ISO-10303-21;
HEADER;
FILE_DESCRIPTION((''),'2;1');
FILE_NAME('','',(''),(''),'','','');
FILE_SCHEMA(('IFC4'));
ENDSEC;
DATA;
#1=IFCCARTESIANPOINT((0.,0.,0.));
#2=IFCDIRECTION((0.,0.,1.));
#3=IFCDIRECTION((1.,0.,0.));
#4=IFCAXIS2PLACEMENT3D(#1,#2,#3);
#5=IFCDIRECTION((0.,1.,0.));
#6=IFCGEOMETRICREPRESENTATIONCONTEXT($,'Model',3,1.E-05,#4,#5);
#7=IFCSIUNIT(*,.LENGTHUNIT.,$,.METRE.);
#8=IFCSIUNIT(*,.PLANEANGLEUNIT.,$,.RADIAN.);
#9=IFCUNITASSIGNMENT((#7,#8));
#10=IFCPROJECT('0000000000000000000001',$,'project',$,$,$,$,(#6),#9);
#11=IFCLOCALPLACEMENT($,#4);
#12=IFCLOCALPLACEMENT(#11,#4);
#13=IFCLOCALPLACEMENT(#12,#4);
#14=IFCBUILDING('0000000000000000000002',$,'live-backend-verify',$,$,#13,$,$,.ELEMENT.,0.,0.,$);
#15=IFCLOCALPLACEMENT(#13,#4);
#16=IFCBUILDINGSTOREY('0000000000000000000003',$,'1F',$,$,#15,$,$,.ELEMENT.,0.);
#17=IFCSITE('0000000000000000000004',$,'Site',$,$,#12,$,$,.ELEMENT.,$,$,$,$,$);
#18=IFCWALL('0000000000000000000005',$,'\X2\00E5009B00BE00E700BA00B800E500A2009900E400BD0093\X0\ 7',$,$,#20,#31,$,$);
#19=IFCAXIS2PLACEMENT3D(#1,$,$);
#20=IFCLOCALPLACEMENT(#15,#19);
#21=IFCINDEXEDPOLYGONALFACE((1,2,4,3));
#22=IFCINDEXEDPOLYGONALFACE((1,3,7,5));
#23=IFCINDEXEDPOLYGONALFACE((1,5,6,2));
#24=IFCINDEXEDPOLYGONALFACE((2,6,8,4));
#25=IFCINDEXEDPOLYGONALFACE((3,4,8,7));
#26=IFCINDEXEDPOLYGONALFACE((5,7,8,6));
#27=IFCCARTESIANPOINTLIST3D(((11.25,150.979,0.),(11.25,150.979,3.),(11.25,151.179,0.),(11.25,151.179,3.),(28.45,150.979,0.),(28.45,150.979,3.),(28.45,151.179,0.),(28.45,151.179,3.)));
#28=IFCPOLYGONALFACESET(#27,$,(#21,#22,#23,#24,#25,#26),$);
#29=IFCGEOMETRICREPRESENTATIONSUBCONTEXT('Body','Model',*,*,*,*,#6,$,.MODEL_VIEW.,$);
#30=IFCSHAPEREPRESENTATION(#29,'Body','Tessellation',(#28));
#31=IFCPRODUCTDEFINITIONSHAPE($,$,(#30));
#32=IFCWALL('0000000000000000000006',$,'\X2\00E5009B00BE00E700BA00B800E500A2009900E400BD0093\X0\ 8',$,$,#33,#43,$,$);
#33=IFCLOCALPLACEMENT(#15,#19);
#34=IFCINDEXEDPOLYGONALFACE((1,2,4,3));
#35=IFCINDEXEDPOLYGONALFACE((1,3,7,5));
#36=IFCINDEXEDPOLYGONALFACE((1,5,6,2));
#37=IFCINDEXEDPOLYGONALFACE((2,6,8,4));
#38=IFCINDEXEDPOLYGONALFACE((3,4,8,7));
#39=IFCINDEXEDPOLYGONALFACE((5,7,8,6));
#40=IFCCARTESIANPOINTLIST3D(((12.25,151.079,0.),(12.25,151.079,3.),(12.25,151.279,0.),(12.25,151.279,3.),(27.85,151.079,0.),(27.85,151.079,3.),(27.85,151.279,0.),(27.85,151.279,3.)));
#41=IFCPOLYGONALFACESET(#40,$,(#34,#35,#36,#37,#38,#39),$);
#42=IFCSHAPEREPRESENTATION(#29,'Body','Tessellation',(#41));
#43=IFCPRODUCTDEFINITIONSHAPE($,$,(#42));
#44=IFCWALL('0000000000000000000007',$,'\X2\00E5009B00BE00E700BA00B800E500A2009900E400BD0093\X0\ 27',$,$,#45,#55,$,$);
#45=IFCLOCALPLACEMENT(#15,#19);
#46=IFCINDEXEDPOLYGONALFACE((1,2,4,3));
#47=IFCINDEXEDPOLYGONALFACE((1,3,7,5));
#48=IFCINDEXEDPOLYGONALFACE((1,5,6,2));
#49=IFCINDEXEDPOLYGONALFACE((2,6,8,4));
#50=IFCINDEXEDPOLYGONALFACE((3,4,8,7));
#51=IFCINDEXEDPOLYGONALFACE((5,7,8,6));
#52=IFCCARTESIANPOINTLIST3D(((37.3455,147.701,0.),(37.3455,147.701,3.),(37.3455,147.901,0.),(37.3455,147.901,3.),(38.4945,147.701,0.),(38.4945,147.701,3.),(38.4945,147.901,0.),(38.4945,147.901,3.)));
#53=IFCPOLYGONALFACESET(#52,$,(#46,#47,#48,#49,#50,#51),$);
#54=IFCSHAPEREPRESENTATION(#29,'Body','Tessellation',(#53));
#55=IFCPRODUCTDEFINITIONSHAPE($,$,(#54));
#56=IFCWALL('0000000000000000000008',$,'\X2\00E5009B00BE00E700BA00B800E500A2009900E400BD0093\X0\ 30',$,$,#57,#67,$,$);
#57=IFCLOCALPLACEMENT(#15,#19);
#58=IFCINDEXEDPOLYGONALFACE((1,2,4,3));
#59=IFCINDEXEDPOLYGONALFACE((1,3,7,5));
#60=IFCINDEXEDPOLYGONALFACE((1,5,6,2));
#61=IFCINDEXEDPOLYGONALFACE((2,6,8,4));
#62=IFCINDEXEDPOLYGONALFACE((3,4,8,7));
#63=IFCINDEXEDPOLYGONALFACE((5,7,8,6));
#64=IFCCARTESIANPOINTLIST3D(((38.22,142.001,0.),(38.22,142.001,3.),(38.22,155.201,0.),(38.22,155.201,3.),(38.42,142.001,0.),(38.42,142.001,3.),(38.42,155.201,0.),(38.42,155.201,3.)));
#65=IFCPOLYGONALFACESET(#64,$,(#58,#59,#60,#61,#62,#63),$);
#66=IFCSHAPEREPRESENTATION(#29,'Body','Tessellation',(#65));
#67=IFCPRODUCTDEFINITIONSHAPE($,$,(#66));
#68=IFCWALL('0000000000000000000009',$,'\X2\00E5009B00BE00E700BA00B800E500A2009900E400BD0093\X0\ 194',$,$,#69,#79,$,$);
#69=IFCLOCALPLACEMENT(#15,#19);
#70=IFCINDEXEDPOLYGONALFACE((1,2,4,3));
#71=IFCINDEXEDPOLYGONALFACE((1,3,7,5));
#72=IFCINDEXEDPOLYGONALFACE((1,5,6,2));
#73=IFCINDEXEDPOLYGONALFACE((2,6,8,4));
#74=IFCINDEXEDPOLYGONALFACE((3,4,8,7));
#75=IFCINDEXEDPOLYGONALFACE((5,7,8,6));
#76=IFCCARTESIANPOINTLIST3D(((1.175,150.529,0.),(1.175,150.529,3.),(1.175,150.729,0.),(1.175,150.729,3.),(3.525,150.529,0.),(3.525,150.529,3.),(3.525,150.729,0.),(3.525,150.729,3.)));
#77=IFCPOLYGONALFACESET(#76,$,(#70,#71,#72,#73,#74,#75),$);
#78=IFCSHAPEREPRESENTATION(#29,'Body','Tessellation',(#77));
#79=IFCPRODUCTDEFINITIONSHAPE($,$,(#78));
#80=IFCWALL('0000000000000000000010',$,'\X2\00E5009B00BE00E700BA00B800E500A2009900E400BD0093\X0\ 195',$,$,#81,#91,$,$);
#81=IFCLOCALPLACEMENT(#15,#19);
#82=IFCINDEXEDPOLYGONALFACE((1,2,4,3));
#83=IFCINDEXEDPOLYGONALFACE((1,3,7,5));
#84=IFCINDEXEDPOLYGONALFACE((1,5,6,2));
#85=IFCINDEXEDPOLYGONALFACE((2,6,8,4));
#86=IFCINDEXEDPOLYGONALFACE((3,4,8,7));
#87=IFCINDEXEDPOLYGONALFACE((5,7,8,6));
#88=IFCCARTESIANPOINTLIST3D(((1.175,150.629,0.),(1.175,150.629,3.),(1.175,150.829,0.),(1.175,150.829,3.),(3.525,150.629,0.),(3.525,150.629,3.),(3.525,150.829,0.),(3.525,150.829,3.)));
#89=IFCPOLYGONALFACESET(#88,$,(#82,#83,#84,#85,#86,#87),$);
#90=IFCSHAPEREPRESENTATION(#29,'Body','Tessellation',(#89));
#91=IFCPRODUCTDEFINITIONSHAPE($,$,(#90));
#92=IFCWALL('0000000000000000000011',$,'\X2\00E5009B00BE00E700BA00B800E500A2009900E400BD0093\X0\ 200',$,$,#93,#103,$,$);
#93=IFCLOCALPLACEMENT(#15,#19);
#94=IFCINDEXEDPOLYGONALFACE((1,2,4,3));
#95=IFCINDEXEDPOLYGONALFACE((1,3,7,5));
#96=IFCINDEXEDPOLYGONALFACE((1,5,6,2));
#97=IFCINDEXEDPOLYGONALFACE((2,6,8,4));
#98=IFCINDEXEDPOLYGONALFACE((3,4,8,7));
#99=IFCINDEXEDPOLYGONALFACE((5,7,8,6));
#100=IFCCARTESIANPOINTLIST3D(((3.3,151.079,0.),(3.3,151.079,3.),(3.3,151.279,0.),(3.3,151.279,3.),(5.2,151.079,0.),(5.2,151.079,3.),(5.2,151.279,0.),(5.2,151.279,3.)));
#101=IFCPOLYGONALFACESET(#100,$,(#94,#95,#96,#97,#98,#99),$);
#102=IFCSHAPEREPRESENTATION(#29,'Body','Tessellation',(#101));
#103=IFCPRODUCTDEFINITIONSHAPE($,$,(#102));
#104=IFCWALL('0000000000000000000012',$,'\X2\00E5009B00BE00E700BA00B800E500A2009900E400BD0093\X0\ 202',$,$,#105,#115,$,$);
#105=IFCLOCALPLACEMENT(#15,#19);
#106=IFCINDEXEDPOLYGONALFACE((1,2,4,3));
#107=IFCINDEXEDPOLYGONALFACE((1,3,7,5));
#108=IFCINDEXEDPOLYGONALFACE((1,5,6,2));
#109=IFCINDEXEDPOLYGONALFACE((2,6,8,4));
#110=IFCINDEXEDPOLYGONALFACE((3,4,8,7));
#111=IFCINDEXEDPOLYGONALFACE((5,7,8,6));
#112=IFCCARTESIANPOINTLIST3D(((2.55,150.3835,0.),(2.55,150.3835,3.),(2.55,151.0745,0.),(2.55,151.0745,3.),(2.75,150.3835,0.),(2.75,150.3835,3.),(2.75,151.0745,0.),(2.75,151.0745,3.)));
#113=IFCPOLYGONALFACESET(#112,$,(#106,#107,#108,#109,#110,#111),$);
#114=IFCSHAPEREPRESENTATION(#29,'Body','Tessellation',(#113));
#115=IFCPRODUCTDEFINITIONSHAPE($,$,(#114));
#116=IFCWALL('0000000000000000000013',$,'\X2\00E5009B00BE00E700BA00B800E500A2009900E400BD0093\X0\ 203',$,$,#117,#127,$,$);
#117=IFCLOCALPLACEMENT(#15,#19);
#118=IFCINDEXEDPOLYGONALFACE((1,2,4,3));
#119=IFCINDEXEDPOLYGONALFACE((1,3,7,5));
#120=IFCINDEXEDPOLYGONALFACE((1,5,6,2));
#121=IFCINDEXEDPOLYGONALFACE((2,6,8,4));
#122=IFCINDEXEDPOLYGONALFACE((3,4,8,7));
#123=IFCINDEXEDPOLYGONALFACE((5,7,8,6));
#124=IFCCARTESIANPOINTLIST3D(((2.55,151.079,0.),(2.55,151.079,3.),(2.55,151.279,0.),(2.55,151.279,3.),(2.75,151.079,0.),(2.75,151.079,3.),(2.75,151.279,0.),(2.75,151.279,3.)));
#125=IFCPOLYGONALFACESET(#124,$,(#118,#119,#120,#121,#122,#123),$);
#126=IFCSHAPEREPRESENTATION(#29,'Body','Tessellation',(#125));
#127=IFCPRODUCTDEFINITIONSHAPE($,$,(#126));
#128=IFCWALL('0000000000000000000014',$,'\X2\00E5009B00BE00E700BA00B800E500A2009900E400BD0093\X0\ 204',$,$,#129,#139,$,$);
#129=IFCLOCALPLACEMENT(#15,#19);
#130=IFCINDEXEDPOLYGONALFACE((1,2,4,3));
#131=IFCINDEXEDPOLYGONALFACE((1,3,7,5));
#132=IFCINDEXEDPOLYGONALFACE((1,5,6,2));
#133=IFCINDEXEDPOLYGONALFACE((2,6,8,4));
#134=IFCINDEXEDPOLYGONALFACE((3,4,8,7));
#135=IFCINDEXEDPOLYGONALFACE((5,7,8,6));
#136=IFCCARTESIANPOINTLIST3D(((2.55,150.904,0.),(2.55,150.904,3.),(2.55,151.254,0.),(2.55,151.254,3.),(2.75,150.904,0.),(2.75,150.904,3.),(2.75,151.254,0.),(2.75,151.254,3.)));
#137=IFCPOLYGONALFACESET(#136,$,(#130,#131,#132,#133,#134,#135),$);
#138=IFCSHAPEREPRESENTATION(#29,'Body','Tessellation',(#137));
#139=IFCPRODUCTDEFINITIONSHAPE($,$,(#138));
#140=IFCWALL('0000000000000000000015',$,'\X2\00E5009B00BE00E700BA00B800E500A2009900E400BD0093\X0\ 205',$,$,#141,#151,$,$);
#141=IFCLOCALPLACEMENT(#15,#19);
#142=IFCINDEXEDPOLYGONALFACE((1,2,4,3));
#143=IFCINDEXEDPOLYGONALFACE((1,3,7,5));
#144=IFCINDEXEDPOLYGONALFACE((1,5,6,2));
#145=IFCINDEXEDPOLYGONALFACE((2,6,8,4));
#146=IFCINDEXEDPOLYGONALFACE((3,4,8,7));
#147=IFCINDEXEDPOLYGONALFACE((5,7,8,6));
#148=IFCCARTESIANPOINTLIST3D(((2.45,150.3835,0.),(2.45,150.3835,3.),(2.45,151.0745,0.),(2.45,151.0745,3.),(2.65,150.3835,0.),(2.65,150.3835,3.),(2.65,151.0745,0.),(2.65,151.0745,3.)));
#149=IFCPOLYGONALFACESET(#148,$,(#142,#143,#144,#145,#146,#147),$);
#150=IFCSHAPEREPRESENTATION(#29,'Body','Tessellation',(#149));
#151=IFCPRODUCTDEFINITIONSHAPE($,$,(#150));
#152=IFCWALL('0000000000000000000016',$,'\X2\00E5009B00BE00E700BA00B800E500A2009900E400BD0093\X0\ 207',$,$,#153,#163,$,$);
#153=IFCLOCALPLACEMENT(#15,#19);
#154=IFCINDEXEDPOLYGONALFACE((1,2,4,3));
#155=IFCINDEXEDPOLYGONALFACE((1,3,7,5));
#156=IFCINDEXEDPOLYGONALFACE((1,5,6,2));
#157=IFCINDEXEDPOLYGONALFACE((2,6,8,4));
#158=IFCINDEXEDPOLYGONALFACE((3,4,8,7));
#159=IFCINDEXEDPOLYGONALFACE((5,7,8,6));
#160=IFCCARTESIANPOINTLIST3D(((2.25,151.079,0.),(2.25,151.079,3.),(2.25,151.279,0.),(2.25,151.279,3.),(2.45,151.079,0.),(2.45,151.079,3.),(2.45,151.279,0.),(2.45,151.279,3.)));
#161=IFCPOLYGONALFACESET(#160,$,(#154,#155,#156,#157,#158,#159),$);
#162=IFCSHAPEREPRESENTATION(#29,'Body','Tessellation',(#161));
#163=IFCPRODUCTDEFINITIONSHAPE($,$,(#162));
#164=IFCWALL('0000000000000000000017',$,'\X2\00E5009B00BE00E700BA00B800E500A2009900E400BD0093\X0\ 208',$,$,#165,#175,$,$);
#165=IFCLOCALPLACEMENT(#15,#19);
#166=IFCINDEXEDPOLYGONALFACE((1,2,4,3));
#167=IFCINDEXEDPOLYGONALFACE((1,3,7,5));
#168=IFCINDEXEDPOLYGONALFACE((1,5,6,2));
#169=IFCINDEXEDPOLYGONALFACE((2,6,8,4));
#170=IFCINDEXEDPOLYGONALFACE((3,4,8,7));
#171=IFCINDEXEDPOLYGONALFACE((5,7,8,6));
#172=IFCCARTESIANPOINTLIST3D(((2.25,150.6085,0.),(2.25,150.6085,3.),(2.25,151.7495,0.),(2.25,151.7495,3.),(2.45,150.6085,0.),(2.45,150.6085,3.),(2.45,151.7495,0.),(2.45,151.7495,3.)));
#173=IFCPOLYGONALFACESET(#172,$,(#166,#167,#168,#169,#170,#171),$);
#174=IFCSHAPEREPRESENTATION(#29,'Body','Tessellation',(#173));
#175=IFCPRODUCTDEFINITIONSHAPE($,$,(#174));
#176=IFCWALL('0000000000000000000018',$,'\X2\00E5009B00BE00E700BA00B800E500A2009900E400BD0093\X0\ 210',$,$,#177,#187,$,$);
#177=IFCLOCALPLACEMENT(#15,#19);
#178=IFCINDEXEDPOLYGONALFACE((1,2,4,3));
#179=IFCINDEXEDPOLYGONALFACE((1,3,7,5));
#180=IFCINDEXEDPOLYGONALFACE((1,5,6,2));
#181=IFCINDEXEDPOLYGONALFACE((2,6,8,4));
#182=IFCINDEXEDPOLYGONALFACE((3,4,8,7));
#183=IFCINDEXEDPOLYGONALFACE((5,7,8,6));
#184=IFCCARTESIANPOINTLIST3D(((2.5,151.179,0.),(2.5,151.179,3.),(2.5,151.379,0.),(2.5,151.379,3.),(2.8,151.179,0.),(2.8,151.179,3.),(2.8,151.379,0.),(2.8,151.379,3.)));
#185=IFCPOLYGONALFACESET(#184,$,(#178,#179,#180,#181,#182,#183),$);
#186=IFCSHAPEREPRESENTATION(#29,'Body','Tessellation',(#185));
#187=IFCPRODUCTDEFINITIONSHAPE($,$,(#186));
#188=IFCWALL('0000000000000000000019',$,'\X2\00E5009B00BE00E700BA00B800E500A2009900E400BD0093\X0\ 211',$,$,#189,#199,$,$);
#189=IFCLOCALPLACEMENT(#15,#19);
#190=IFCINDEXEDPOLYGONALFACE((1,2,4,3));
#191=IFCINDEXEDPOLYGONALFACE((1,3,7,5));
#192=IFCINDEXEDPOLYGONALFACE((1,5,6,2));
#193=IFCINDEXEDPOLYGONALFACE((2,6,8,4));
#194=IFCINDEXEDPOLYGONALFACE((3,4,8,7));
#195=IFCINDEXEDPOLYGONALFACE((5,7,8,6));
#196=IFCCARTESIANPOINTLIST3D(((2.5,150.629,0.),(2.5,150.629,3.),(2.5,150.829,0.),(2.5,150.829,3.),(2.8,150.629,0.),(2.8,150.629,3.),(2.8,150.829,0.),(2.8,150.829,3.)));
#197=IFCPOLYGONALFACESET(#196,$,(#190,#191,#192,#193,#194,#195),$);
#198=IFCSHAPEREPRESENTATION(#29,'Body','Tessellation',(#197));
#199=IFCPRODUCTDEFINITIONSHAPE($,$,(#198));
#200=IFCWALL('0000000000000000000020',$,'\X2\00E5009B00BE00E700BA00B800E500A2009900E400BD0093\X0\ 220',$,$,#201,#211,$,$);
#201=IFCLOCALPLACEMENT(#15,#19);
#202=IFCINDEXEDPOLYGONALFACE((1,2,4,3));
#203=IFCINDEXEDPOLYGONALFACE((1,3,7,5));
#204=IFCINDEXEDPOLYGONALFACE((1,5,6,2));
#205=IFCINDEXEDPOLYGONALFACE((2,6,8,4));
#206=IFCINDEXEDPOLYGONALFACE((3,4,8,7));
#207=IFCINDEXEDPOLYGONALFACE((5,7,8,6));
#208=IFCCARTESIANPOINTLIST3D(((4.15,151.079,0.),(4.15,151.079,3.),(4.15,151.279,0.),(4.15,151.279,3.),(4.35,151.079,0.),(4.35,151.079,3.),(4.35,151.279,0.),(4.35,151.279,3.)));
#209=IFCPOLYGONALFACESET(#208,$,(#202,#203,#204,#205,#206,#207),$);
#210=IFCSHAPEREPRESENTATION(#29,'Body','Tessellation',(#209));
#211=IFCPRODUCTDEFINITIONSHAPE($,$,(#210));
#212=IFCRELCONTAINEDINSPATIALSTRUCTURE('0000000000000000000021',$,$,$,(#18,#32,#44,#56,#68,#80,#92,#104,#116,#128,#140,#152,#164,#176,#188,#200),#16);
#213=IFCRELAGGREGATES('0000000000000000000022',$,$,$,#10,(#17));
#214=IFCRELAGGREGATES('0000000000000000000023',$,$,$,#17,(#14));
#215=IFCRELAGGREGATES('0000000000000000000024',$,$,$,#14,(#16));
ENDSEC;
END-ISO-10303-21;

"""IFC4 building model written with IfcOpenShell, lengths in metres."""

from ifc_helpers import new_model, si_unit, direction, frame, frame_2d, origin_with_axes, place, context, subcontext, project, spatial, rectangle, extrude, element, save


model = new_model("IFC4")

# Units and contexts
model_context = context("Model", 3, precision=1e-05, world=origin_with_axes(), true_north=direction((0.0, 1.0, 0.0)))
body_context = subcontext(model_context, "Body", "Model", "MODEL_VIEW")
ifc_project = project(units=[si_unit("LENGTHUNIT", "METRE"), si_unit("PLANEANGLEUNIT", "RADIAN")], contexts=[model_context])

# Site, building, storey
placement = place(None, origin_with_axes())
site_placement = place(placement, origin_with_axes())
site = spatial("IfcSite", under=ifc_project, at=site_placement, Name="Site", CompositionType="ELEMENT")
building_placement = place(site_placement, origin_with_axes())
building = spatial("IfcBuilding", under=site, at=building_placement, Name="live-backend-verify", CompositionType="ELEMENT", ElevationOfRefHeight=0.0, ElevationOfTerrain=0.0)
storey_placement = place(building_placement, origin_with_axes())
storey = spatial("IfcBuildingStorey", under=building, at=storey_placement, Name="1F", CompositionType="ELEMENT", Elevation=0.0)

# Walls
wall_1_placement = place(storey_placement, frame((19.85, 151.079, 0.0), z_axis=(0.0, 0.0, 1.0), x_axis=(-1.0, 0.0, 0.0)))
element("IfcWall", 1, at=wall_1_placement, inside=storey, Name="å\u009b¾çº¸å¢\u0099ä½\u0093 7", context=body_context, shape_type="SweptSolid", body=[
    extrude(rectangle(XDim=17.2, YDim=0.2, at=frame_2d((0.0, 0.0), x_axis=(1.0, 0.0, 0.0))), frame((0.0, 0.0, 0.0), z_axis=(0.0, 0.0, 1.0)), (0.0, 0.0, 1.0), 3.0),
])
wall_2_placement = place(storey_placement, frame((20.05, 151.179, 0.0), z_axis=(0.0, 0.0, 1.0), x_axis=(-1.0, 0.0, 0.0)))
element("IfcWall", 2, at=wall_2_placement, inside=storey, Name="å\u009b¾çº¸å¢\u0099ä½\u0093 8", context=body_context, shape_type="SweptSolid", body=[
    extrude(rectangle(XDim=15.6, YDim=0.2, at=frame_2d((0.0, 0.0), x_axis=(1.0, 0.0, 0.0))), frame((0.0, 0.0, 0.0), z_axis=(0.0, 0.0, 1.0)), (0.0, 0.0, 1.0), 3.0),
])
wall_3_placement = place(storey_placement, frame((37.92, 147.801, 0.0), z_axis=(0.0, 0.0, 1.0), x_axis=(-1.0, 0.0, 0.0)))
element("IfcWall", 3, at=wall_3_placement, inside=storey, Name="å\u009b¾çº¸å¢\u0099ä½\u0093 27", context=body_context, shape_type="SweptSolid", body=[
    extrude(rectangle(XDim=1.149, YDim=0.2, at=frame_2d((0.0, 0.0), x_axis=(1.0, 0.0, 0.0))), frame((0.0, 0.0, 0.0), z_axis=(0.0, 0.0, 1.0)), (0.0, 0.0, 1.0), 3.0),
])
wall_4_placement = place(storey_placement, frame((38.32, 148.601, 0.0), z_axis=(0.0, 0.0, 1.0), x_axis=(0.0, 1.0, 0.0)))
element("IfcWall", 4, at=wall_4_placement, inside=storey, Name="å\u009b¾çº¸å¢\u0099ä½\u0093 30", context=body_context, shape_type="SweptSolid", body=[
    extrude(rectangle(XDim=13.2, YDim=0.2, at=frame_2d((0.0, 0.0), x_axis=(1.0, 0.0, 0.0))), frame((0.0, 0.0, 0.0), z_axis=(0.0, 0.0, 1.0)), (0.0, 0.0, 1.0), 3.0),
])
for number, where, z_axis, x_axis, name in (
    (5, (2.35, 150.629, 0.0), (0.0, 0.0, 1.0), (-1.0, 0.0, 0.0), "å\u009b¾çº¸å¢\u0099ä½\u0093 194"),
    (6, (2.35, 150.729, 0.0), (0.0, 0.0, 1.0), (-1.0, 0.0, 0.0), "å\u009b¾çº¸å¢\u0099ä½\u0093 195"),
):
    element("IfcWall", number, at=place(storey_placement, frame(where, z_axis=z_axis, x_axis=x_axis)), inside=storey, Name=name, context=body_context, shape_type="SweptSolid", body=[
        extrude(rectangle(XDim=2.35, YDim=0.2, at=frame_2d((0.0, 0.0), x_axis=(1.0, 0.0, 0.0))), frame((0.0, 0.0, 0.0), z_axis=(0.0, 0.0, 1.0)), (0.0, 0.0, 1.0), 3.0),
    ])
wall_5_placement = place(storey_placement, frame((4.25, 151.179, 0.0), z_axis=(0.0, 0.0, 1.0), x_axis=(-1.0, 0.0, 0.0)))
element("IfcWall", 7, at=wall_5_placement, inside=storey, Name="å\u009b¾çº¸å¢\u0099ä½\u0093 200", context=body_context, shape_type="SweptSolid", body=[
    extrude(rectangle(XDim=1.9, YDim=0.2, at=frame_2d((0.0, 0.0), x_axis=(1.0, 0.0, 0.0))), frame((0.0, 0.0, 0.0), z_axis=(0.0, 0.0, 1.0)), (0.0, 0.0, 1.0), 3.0),
])
wall_6_placement = place(storey_placement, frame((2.65, 150.729, 0.0), z_axis=(0.0, 0.0, 1.0), x_axis=(0.0, -1.0, 0.0)))
element("IfcWall", 8, at=wall_6_placement, inside=storey, Name="å\u009b¾çº¸å¢\u0099ä½\u0093 202", context=body_context, shape_type="SweptSolid", body=[
    extrude(rectangle(XDim=0.691, YDim=0.2, at=frame_2d((0.0, 0.0), x_axis=(1.0, 0.0, 0.0))), frame((0.0, 0.0, 0.0), z_axis=(0.0, 0.0, 1.0)), (0.0, 0.0, 1.0), 3.0),
])
wall_7_placement = place(storey_placement, frame((2.65, 151.179, 0.0), z_axis=(0.0, 0.0, 1.0), x_axis=(0.0, 1.0, 0.0)))
element("IfcWall", 9, at=wall_7_placement, inside=storey, Name="å\u009b¾çº¸å¢\u0099ä½\u0093 203", context=body_context, shape_type="SweptSolid", body=[
    extrude(rectangle(XDim=0.2, YDim=0.2, at=frame_2d((0.0, 0.0), x_axis=(1.0, 0.0, 0.0))), frame((0.0, 0.0, 0.0), z_axis=(0.0, 0.0, 1.0)), (0.0, 0.0, 1.0), 3.0),
])
wall_8_placement = place(storey_placement, frame((2.65, 151.079, 0.0), z_axis=(0.0, 0.0, 1.0), x_axis=(0.0, -1.0, 0.0)))
element("IfcWall", 10, at=wall_8_placement, inside=storey, Name="å\u009b¾çº¸å¢\u0099ä½\u0093 204", context=body_context, shape_type="SweptSolid", body=[
    extrude(rectangle(XDim=0.35, YDim=0.2, at=frame_2d((0.0, 0.0), x_axis=(1.0, 0.0, 0.0))), frame((0.0, 0.0, 0.0), z_axis=(0.0, 0.0, 1.0)), (0.0, 0.0, 1.0), 3.0),
])
wall_9_placement = place(storey_placement, frame((2.55, 150.729, 0.0), z_axis=(0.0, 0.0, 1.0), x_axis=(0.0, -1.0, 0.0)))
element("IfcWall", 11, at=wall_9_placement, inside=storey, Name="å\u009b¾çº¸å¢\u0099ä½\u0093 205", context=body_context, shape_type="SweptSolid", body=[
    extrude(rectangle(XDim=0.691, YDim=0.2, at=frame_2d((0.0, 0.0), x_axis=(1.0, 0.0, 0.0))), frame((0.0, 0.0, 0.0), z_axis=(0.0, 0.0, 1.0)), (0.0, 0.0, 1.0), 3.0),
])
wall_10_placement = place(storey_placement, frame((2.35, 151.179, 0.0), z_axis=(0.0, 0.0, 1.0), x_axis=(0.0, 1.0, 0.0)))
element("IfcWall", 12, at=wall_10_placement, inside=storey, Name="å\u009b¾çº¸å¢\u0099ä½\u0093 207", context=body_context, shape_type="SweptSolid", body=[
    extrude(rectangle(XDim=0.2, YDim=0.2, at=frame_2d((0.0, 0.0), x_axis=(1.0, 0.0, 0.0))), frame((0.0, 0.0, 0.0), z_axis=(0.0, 0.0, 1.0)), (0.0, 0.0, 1.0), 3.0),
])
wall_11_placement = place(storey_placement, frame((2.35, 151.179, 0.0), z_axis=(0.0, 0.0, 1.0), x_axis=(0.0, -1.0, 0.0)))
element("IfcWall", 13, at=wall_11_placement, inside=storey, Name="å\u009b¾çº¸å¢\u0099ä½\u0093 208", context=body_context, shape_type="SweptSolid", body=[
    extrude(rectangle(XDim=1.141, YDim=0.2, at=frame_2d((0.0, 0.0), x_axis=(1.0, 0.0, 0.0))), frame((0.0, 0.0, 0.0), z_axis=(0.0, 0.0, 1.0)), (0.0, 0.0, 1.0), 3.0),
])
for number, where, z_axis, x_axis, name in (
    (14, (2.65, 151.279, 0.0), (0.0, 0.0, 1.0), (-1.0, 0.0, 0.0), "å\u009b¾çº¸å¢\u0099ä½\u0093 210"),
    (15, (2.65, 150.729, 0.0), (0.0, 0.0, 1.0), (-1.0, 0.0, 0.0), "å\u009b¾çº¸å¢\u0099ä½\u0093 211"),
):
    element("IfcWall", number, at=place(storey_placement, frame(where, z_axis=z_axis, x_axis=x_axis)), inside=storey, Name=name, context=body_context, shape_type="SweptSolid", body=[
        extrude(rectangle(XDim=0.3, YDim=0.2, at=frame_2d((0.0, 0.0), x_axis=(1.0, 0.0, 0.0))), frame((0.0, 0.0, 0.0), z_axis=(0.0, 0.0, 1.0)), (0.0, 0.0, 1.0), 3.0),
    ])
for number, where, z_axis, x_axis, name in (
    (16, (4.25, 151.179, 0.0), (0.0, 0.0, 1.0), (1.0, 0.0, 0.0), "å\u009b¾çº¸å¢\u0099ä½\u0093 220"),
):
    element("IfcWall", number, at=place(storey_placement, frame(where, z_axis=z_axis, x_axis=x_axis)), inside=storey, Name=name, context=body_context, shape_type="SweptSolid", body=[
        extrude(rectangle(XDim=0.2, YDim=0.2, at=frame_2d((0.0, 0.0), x_axis=(1.0, 0.0, 0.0))), frame((0.0, 0.0, 0.0), z_axis=(0.0, 0.0, 1.0)), (0.0, 0.0, 1.0), 3.0),
    ])

save(model, "model.ifc")
